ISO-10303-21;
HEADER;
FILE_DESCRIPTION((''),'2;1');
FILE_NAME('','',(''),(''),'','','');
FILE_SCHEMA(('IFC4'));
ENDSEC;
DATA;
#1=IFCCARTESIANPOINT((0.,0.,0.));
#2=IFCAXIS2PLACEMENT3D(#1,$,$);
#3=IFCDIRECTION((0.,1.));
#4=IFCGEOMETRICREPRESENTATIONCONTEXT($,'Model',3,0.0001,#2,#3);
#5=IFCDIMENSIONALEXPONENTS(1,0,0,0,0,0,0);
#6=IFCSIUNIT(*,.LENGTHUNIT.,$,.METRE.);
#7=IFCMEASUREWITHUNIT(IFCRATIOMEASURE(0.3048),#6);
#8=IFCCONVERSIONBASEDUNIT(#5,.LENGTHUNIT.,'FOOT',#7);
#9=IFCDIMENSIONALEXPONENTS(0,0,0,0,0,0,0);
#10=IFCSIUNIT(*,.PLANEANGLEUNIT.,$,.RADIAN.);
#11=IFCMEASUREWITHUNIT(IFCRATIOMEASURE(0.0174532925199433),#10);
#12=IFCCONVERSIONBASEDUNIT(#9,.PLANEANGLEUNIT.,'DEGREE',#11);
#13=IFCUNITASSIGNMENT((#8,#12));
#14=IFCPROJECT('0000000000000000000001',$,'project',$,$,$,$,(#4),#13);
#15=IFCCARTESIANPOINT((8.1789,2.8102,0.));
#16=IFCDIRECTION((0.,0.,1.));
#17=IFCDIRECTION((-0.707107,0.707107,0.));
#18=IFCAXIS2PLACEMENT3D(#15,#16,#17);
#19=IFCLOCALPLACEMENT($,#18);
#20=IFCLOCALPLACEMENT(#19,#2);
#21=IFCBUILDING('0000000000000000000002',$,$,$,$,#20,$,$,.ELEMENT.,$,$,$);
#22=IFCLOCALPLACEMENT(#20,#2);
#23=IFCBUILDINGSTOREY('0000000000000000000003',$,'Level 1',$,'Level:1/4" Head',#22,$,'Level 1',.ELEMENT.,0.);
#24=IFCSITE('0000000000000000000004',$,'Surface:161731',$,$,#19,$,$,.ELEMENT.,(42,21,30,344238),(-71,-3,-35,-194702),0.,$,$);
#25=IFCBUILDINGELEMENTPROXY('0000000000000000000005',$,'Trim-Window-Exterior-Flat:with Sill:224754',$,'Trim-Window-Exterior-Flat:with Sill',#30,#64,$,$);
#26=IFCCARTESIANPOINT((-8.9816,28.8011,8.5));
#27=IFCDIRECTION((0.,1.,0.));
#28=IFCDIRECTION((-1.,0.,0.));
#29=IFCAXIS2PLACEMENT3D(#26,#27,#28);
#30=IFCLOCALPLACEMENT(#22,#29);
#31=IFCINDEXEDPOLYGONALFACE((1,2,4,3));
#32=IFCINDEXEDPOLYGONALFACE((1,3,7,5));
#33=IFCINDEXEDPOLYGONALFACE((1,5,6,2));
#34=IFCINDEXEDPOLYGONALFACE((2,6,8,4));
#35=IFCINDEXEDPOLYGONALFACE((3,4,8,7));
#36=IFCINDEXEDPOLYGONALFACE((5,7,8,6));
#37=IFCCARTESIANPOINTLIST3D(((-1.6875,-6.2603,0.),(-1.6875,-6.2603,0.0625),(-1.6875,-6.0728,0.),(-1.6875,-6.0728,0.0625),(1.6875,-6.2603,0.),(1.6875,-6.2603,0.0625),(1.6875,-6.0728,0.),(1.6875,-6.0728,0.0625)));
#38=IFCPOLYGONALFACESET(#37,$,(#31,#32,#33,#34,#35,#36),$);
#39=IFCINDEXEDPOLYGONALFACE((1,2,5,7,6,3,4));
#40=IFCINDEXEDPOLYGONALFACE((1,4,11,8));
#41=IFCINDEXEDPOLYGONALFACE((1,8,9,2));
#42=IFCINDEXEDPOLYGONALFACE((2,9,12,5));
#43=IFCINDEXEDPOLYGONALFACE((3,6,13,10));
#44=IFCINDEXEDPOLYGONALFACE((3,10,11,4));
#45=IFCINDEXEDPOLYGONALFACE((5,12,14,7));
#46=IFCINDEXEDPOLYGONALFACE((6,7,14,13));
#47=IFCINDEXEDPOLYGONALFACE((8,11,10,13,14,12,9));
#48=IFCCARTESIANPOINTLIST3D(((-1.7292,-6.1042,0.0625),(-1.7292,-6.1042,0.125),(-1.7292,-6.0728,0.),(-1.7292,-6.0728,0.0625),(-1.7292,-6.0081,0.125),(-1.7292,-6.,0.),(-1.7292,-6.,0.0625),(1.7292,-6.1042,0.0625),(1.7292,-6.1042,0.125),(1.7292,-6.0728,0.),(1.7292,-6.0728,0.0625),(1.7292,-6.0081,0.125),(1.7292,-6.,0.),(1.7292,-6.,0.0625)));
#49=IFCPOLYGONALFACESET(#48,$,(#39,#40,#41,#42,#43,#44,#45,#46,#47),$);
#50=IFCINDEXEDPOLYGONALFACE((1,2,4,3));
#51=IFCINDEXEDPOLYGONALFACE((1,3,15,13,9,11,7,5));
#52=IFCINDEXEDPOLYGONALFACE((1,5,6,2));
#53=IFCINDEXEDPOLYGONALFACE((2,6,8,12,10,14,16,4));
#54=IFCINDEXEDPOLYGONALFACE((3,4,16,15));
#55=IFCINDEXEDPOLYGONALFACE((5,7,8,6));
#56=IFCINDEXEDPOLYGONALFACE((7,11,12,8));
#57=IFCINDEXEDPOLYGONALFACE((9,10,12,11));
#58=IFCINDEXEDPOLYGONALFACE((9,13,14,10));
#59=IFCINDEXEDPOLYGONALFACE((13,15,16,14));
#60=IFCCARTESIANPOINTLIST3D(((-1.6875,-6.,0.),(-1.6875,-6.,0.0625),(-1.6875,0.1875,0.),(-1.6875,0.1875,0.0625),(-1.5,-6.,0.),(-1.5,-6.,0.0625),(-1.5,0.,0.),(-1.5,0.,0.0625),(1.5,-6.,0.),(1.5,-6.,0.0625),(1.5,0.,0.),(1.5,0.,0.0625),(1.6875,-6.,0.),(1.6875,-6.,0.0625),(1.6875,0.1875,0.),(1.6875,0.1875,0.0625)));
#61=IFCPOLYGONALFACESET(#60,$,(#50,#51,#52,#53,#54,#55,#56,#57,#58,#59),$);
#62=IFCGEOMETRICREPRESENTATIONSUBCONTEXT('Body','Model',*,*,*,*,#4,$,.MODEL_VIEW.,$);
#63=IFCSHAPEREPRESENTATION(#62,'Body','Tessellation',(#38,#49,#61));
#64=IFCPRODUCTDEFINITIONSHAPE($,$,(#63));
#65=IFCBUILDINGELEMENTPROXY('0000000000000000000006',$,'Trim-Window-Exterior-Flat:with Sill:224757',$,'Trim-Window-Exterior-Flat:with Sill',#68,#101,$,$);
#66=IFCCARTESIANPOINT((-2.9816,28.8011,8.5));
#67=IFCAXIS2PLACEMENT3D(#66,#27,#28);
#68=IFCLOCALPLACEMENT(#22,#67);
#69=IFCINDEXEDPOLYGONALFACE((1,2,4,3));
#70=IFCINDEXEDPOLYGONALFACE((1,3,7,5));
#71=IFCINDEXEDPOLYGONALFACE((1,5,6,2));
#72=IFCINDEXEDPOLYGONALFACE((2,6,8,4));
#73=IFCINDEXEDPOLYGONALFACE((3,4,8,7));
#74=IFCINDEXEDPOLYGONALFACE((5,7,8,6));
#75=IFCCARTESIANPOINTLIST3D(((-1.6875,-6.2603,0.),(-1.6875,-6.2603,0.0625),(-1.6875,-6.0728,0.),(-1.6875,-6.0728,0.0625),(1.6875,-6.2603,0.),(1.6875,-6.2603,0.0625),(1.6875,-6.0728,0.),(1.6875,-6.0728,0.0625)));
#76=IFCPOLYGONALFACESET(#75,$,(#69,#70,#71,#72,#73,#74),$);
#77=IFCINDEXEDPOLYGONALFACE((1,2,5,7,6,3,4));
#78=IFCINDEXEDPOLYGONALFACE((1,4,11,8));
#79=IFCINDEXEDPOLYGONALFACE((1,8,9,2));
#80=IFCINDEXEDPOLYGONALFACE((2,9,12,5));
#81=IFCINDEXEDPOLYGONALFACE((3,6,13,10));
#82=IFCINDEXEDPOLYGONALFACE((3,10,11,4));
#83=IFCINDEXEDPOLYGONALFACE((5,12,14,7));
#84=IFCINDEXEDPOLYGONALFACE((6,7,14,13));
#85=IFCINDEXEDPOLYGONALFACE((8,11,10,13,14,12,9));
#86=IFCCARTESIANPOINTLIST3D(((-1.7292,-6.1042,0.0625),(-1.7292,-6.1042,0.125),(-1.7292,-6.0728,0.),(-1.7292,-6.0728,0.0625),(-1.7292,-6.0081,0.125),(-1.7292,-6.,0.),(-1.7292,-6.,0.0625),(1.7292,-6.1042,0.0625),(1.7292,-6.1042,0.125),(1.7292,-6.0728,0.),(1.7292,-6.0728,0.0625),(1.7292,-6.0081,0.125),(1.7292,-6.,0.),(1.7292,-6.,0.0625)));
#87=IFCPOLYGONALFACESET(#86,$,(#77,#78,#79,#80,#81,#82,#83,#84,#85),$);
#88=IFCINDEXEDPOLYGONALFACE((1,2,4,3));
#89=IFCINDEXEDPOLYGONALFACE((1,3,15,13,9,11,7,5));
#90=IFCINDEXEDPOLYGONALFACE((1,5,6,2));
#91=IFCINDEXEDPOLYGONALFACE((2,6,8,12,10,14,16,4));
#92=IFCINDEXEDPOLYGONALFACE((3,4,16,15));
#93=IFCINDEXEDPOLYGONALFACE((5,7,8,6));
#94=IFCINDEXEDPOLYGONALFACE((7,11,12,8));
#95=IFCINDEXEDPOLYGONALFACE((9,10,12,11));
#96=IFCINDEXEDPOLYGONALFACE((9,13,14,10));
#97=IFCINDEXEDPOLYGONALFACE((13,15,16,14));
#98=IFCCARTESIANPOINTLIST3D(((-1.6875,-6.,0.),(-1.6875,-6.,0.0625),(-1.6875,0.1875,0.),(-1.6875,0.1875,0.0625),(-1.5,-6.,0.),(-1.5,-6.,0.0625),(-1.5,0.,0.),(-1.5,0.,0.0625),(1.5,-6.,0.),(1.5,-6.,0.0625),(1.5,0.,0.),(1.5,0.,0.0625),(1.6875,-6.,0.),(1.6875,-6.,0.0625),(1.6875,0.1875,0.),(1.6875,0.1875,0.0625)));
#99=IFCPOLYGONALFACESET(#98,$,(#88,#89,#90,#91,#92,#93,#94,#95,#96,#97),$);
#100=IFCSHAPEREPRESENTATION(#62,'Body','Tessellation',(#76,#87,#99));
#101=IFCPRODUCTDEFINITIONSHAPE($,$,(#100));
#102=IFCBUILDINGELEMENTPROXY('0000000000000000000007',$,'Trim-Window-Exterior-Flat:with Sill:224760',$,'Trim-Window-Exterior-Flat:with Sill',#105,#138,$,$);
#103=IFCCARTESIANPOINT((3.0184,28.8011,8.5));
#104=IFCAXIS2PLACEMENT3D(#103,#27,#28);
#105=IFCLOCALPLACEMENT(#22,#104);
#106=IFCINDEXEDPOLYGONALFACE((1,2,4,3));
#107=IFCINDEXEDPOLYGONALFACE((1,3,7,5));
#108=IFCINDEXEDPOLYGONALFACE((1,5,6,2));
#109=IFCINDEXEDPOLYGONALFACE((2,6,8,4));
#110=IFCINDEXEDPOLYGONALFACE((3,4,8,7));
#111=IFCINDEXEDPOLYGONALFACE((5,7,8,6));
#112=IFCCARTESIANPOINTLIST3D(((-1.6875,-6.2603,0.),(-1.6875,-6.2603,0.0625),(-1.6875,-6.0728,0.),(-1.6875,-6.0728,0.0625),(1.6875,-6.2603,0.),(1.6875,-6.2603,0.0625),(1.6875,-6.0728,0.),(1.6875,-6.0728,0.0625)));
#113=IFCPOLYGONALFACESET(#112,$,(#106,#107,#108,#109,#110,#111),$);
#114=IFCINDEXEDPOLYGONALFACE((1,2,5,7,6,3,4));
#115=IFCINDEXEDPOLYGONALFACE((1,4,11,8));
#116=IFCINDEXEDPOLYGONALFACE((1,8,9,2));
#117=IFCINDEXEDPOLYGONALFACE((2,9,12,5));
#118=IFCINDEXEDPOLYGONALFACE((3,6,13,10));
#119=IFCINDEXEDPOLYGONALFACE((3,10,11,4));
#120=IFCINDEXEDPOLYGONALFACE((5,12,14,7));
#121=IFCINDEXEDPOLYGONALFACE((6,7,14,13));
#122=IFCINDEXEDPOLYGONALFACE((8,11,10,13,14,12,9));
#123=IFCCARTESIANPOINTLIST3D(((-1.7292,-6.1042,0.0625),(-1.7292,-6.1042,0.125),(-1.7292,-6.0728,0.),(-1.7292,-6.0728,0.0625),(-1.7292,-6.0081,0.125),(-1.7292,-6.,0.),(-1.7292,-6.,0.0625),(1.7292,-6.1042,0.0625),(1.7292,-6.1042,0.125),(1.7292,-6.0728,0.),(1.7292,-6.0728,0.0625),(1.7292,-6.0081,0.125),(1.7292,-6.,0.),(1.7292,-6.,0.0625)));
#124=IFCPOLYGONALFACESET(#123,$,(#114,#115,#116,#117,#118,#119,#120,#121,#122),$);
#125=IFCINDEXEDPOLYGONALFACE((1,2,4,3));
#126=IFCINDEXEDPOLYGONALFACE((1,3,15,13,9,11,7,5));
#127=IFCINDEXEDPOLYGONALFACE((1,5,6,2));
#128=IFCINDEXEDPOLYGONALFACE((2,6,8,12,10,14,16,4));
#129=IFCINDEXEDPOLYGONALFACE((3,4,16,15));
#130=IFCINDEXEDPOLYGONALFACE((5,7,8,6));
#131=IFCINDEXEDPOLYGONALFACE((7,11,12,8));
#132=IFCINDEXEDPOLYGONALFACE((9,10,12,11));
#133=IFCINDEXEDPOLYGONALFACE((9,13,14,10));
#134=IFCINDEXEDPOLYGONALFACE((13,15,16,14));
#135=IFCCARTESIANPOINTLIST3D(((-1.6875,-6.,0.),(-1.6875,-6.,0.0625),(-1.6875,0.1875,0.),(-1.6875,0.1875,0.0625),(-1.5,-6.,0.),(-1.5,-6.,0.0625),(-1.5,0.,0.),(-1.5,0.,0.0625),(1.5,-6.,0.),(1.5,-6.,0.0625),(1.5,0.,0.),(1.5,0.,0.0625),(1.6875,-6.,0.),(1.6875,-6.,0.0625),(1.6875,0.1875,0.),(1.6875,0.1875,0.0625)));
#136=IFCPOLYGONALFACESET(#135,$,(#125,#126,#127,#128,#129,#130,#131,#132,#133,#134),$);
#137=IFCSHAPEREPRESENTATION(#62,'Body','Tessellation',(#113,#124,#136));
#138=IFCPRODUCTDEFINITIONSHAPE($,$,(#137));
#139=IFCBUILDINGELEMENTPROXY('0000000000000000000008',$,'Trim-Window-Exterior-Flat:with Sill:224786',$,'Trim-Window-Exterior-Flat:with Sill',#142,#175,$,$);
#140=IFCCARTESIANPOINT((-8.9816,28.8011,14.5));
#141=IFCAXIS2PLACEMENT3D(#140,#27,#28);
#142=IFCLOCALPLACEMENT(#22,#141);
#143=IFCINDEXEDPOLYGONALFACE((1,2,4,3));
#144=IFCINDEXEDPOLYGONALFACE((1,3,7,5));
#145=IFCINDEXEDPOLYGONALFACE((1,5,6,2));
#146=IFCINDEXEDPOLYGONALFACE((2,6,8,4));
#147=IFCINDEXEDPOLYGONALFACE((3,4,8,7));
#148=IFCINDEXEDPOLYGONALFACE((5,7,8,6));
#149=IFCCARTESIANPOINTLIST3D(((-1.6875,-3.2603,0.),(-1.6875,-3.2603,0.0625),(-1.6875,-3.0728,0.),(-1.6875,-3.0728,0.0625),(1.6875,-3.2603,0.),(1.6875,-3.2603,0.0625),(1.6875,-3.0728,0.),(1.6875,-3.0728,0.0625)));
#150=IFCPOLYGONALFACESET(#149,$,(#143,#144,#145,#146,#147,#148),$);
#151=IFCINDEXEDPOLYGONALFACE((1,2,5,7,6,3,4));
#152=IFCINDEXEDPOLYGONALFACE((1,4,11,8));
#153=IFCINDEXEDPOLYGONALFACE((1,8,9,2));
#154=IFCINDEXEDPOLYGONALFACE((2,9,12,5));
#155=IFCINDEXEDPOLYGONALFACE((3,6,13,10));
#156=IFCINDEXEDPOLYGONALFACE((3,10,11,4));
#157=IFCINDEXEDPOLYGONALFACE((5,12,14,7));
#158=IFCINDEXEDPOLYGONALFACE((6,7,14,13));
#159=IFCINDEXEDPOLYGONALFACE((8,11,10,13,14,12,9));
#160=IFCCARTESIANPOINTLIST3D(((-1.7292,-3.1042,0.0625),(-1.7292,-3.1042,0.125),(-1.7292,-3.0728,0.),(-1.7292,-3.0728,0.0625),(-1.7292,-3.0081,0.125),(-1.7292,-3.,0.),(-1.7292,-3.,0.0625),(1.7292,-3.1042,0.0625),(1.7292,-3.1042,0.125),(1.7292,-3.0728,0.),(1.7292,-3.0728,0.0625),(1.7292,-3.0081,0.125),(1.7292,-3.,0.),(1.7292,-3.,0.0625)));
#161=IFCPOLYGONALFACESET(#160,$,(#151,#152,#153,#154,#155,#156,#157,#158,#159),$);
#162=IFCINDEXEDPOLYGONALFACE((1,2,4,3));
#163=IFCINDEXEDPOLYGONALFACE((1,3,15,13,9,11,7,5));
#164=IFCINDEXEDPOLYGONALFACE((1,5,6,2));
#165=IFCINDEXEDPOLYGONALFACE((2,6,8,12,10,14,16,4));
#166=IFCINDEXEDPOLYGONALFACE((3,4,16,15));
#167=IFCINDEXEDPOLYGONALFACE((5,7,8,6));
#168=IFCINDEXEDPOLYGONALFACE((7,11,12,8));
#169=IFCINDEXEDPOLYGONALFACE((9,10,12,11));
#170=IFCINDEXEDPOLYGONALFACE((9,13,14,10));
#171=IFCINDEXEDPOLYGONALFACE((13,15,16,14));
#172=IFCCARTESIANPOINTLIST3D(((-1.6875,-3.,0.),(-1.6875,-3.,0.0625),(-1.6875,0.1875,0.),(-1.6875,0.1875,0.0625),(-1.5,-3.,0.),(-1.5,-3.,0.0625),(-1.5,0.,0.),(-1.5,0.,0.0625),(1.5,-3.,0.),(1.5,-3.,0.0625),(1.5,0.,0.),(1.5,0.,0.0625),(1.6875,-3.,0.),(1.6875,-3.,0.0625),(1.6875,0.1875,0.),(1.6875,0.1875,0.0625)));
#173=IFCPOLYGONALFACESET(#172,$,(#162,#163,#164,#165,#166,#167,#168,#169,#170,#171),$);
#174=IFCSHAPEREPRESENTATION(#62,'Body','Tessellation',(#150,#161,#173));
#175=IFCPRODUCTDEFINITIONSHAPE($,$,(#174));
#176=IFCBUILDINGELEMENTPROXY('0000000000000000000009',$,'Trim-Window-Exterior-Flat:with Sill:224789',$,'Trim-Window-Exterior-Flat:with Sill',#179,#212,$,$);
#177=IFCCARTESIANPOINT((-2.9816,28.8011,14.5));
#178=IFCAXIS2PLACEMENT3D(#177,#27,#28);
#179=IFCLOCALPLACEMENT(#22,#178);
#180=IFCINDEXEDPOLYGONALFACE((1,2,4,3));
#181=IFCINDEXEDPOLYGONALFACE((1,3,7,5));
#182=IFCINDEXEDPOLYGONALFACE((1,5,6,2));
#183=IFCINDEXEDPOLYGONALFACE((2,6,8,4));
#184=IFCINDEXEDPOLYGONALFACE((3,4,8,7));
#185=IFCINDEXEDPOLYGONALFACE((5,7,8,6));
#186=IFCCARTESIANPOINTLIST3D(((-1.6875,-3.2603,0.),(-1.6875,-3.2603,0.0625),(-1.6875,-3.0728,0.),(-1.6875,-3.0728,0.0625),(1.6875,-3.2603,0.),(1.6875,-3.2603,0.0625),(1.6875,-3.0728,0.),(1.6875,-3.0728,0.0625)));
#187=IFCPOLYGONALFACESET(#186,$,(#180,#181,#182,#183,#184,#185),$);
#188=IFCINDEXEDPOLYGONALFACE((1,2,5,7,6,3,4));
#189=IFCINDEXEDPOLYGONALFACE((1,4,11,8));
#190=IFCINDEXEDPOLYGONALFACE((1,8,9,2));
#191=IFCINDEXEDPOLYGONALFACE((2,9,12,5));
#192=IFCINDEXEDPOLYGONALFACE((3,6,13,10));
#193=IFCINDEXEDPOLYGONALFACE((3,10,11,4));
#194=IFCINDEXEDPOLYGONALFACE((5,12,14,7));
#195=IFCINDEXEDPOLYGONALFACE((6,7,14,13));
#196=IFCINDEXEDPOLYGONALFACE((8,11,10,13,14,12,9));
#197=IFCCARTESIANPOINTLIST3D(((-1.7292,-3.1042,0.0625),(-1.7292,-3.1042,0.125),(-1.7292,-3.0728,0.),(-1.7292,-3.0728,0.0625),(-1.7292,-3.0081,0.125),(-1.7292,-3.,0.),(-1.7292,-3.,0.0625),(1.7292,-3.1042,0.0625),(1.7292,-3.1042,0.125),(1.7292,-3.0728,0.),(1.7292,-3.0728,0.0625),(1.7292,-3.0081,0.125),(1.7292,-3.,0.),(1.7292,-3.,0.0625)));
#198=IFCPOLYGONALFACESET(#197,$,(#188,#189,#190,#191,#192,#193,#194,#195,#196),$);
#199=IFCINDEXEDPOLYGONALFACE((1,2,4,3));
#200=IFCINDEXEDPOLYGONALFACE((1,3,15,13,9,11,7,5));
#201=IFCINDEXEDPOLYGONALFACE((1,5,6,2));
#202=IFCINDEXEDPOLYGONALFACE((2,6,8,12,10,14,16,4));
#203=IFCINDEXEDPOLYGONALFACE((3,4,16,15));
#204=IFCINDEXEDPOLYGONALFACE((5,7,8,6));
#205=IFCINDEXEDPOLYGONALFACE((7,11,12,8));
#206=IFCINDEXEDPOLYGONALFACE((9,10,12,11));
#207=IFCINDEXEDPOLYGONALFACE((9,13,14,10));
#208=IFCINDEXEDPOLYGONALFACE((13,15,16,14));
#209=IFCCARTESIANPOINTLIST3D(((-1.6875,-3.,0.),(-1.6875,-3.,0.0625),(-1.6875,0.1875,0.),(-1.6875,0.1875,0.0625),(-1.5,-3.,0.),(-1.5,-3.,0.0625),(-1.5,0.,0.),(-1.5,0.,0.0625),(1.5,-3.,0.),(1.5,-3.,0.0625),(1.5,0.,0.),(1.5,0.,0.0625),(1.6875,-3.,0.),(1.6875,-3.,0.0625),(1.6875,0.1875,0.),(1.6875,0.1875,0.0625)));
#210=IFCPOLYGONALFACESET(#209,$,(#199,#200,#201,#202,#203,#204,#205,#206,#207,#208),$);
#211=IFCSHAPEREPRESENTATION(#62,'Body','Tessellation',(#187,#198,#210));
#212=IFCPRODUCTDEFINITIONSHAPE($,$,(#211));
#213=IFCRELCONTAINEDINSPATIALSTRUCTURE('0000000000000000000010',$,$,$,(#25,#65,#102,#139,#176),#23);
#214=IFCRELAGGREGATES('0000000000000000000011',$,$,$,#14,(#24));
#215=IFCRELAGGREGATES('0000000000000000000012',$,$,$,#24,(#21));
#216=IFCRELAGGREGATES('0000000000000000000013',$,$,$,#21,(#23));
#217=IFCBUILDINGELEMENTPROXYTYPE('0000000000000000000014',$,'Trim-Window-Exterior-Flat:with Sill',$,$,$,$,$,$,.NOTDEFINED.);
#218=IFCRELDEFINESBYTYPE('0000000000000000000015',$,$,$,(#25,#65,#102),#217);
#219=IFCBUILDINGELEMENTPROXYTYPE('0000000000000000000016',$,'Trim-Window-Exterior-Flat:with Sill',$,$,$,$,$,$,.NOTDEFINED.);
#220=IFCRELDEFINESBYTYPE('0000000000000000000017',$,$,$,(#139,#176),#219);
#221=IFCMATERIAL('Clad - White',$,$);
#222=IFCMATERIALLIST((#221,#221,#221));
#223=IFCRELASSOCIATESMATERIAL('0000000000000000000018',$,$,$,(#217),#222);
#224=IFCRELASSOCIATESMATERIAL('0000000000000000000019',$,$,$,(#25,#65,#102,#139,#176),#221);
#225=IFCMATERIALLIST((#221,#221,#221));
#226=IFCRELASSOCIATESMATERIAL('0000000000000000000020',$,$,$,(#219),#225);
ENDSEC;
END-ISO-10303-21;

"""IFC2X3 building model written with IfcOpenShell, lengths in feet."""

from ifc_helpers import new_model, entity, si_unit, converted_unit, direction, frame, frame_2d, origin, origin_2d_with_axis, place, context, subcontext, project, spatial, polyline, rectangle, outline, extrude, source, transform, mapped, material, material_list, type_object, type_shapes, element, save


model = new_model("IFC2X3")

# Units and contexts
model_context = context("Model", 3, precision=0.0001, world=origin(), true_north=direction((0.0, 1.0)))
body_context = subcontext(model_context, "Body", "Model", "MODEL_VIEW")
ifc_project = project(units=[converted_unit("LENGTHUNIT", "FOOT", entity("IfcRatioMeasure", 0.3048), si_unit("LENGTHUNIT", "METRE"), dimensions=[1, 0, 0, 0, 0, 0, 0]), converted_unit("PLANEANGLEUNIT", "DEGREE", entity("IfcRatioMeasure", 0.0174532925199433), si_unit("PLANEANGLEUNIT", "RADIAN"), dimensions=[0, 0, 0, 0, 0, 0, 0])], contexts=[model_context])

# Site, building, storey
site_placement = place(None, frame((8.1789, 2.8102, 0.0), z_axis=(0.0, 0.0, 1.0), x_axis=(-0.707107, 0.707107, 0.0)))
site = spatial("IfcSite", under=ifc_project, at=site_placement, Name="Surface:161731", CompositionType="ELEMENT", RefLatitude=(42, 21, 30, 344238), RefLongitude=(-71, -3, -35, -194702), RefElevation=0.0)
building_placement = place(site_placement, origin())
building = spatial("IfcBuilding", under=site, at=building_placement, CompositionType="ELEMENT")
storey_placement = place(building_placement, origin())
storey = spatial("IfcBuildingStorey", under=building, at=storey_placement, Name="Level 1", ObjectType="Level:1/4\" Head", LongName="Level 1", CompositionType="ELEMENT", Elevation=0.0)

# Building element proxies
ifc_material_1 = material(Name="Clad - White")
ifc_material_list_1 = material_list([ifc_material_1, ifc_material_1, ifc_material_1])
building_element_proxy_type_1 = type_object("IfcBuildingElementProxyType", Name="Trim-Window-Exterior-Flat:with Sill", PredefinedType="NOTDEFINED", material=ifc_material_list_1)
shared_shape_1 = source(origin(), body_context, "Body", "SweptSolid", [
    extrude(rectangle(XDim=3.375, YDim=0.1875, at=origin_2d_with_axis()), frame((0.0, -6.1665, 0.0), z_axis=(0.0, 0.0, 1.0), x_axis=(-1.0, 0.0, 0.0)), (0.0, 0.0, 1.0), 0.0625),
    extrude(outline(polyline([(-0.0625, -0.0525), (0.0, -0.0525), (0.0, -0.0211), (0.0625, -0.0211), (0.0625, 0.0517), (0.0, 0.0517), (-0.0625, 0.0436), (-0.0625, -0.0525)])), frame((-1.7292, -6.0517, 0.0625), z_axis=(1.0, 0.0, 0.0), x_axis=(0.0, 0.0, -1.0)), (0.0, 0.0, 1.0), 3.4583),
    extrude(outline(polyline([(-3.1406, -1.6875), (3.0469, -1.6875), (3.0469, -1.5), (-2.9531, -1.5), (-2.9531, 1.5), (3.0469, 1.5), (3.0469, 1.6875), (-3.1406, 1.6875), (-3.1406, -1.6875)])), frame((0.0, -2.9531, 0.0), z_axis=(0.0, 0.0, 1.0), x_axis=(0.0, -1.0, 0.0)), (0.0, 0.0, 1.0), 0.0625),
])
type_shapes(building_element_proxy_type_1, [shared_shape_1])
for number, where, z_axis, x_axis, name in (
    (1, (-8.9816, 28.8011, 8.5), (0.0, 1.0, 0.0), (-1.0, 0.0, 0.0), "Trim-Window-Exterior-Flat:with Sill:224754"),
    (2, (-2.9816, 28.8011, 8.5), (0.0, 1.0, 0.0), (-1.0, 0.0, 0.0), "Trim-Window-Exterior-Flat:with Sill:224757"),
    (3, (3.0184, 28.8011, 8.5), (0.0, 1.0, 0.0), (-1.0, 0.0, 0.0), "Trim-Window-Exterior-Flat:with Sill:224760"),
):
    element("IfcBuildingElementProxy", number, at=place(storey_placement, frame(where, z_axis=z_axis, x_axis=x_axis)), inside=storey, type_object=building_element_proxy_type_1, material=ifc_material_1, Name=name, ObjectType="Trim-Window-Exterior-Flat:with Sill", context=body_context, shape_type="MappedRepresentation", body=[
        mapped(shared_shape_1, transform((0.0, 0.0, 0.0), scale=1.0)),
    ])
ifc_material_list_2 = material_list([ifc_material_1, ifc_material_1, ifc_material_1])
building_element_proxy_type_2 = type_object("IfcBuildingElementProxyType", Name="Trim-Window-Exterior-Flat:with Sill", PredefinedType="NOTDEFINED", material=ifc_material_list_2)
shared_shape_2 = source(origin(), body_context, "Body", "SweptSolid", [
    extrude(rectangle(XDim=3.375, YDim=0.1875, at=frame_2d((0.0, 0.0), x_axis=(1.0, 0.0))), frame((0.0, -3.1665, 0.0), z_axis=(0.0, 0.0, 1.0), x_axis=(-1.0, 0.0, 0.0)), (0.0, 0.0, 1.0), 0.0625),
    extrude(outline(polyline([(-0.0625, -0.0525), (0.0, -0.0525), (0.0, -0.0211), (0.0625, -0.0211), (0.0625, 0.0517), (0.0, 0.0517), (-0.0625, 0.0436), (-0.0625, -0.0525)])), frame((-1.7292, -3.0517, 0.0625), z_axis=(1.0, 0.0, 0.0), x_axis=(0.0, 0.0, -1.0)), (0.0, 0.0, 1.0), 3.4583),
    extrude(outline(polyline([(-1.6406, -1.6875), (1.5469, -1.6875), (1.5469, -1.5), (-1.4531, -1.5), (-1.4531, 1.5), (1.5469, 1.5), (1.5469, 1.6875), (-1.6406, 1.6875), (-1.6406, -1.6875)])), frame((0.0, -1.4531, 0.0), z_axis=(0.0, 0.0, 1.0), x_axis=(0.0, -1.0, 0.0)), (0.0, 0.0, 1.0), 0.0625),
])
type_shapes(building_element_proxy_type_2, [shared_shape_2])
for number, where, z_axis, x_axis, name in (
    (4, (-8.9816, 28.8011, 14.5), (0.0, 1.0, 0.0), (-1.0, 0.0, 0.0), "Trim-Window-Exterior-Flat:with Sill:224786"),
    (5, (-2.9816, 28.8011, 14.5), (0.0, 1.0, 0.0), (-1.0, 0.0, 0.0), "Trim-Window-Exterior-Flat:with Sill:224789"),
):
    element("IfcBuildingElementProxy", number, at=place(storey_placement, frame(where, z_axis=z_axis, x_axis=x_axis)), inside=storey, type_object=building_element_proxy_type_2, material=ifc_material_1, Name=name, ObjectType="Trim-Window-Exterior-Flat:with Sill", context=body_context, shape_type="MappedRepresentation", body=[
        mapped(shared_shape_2, transform((0.0, 0.0, 0.0), scale=1.0)),
    ])

save(model, "model.ifc")
